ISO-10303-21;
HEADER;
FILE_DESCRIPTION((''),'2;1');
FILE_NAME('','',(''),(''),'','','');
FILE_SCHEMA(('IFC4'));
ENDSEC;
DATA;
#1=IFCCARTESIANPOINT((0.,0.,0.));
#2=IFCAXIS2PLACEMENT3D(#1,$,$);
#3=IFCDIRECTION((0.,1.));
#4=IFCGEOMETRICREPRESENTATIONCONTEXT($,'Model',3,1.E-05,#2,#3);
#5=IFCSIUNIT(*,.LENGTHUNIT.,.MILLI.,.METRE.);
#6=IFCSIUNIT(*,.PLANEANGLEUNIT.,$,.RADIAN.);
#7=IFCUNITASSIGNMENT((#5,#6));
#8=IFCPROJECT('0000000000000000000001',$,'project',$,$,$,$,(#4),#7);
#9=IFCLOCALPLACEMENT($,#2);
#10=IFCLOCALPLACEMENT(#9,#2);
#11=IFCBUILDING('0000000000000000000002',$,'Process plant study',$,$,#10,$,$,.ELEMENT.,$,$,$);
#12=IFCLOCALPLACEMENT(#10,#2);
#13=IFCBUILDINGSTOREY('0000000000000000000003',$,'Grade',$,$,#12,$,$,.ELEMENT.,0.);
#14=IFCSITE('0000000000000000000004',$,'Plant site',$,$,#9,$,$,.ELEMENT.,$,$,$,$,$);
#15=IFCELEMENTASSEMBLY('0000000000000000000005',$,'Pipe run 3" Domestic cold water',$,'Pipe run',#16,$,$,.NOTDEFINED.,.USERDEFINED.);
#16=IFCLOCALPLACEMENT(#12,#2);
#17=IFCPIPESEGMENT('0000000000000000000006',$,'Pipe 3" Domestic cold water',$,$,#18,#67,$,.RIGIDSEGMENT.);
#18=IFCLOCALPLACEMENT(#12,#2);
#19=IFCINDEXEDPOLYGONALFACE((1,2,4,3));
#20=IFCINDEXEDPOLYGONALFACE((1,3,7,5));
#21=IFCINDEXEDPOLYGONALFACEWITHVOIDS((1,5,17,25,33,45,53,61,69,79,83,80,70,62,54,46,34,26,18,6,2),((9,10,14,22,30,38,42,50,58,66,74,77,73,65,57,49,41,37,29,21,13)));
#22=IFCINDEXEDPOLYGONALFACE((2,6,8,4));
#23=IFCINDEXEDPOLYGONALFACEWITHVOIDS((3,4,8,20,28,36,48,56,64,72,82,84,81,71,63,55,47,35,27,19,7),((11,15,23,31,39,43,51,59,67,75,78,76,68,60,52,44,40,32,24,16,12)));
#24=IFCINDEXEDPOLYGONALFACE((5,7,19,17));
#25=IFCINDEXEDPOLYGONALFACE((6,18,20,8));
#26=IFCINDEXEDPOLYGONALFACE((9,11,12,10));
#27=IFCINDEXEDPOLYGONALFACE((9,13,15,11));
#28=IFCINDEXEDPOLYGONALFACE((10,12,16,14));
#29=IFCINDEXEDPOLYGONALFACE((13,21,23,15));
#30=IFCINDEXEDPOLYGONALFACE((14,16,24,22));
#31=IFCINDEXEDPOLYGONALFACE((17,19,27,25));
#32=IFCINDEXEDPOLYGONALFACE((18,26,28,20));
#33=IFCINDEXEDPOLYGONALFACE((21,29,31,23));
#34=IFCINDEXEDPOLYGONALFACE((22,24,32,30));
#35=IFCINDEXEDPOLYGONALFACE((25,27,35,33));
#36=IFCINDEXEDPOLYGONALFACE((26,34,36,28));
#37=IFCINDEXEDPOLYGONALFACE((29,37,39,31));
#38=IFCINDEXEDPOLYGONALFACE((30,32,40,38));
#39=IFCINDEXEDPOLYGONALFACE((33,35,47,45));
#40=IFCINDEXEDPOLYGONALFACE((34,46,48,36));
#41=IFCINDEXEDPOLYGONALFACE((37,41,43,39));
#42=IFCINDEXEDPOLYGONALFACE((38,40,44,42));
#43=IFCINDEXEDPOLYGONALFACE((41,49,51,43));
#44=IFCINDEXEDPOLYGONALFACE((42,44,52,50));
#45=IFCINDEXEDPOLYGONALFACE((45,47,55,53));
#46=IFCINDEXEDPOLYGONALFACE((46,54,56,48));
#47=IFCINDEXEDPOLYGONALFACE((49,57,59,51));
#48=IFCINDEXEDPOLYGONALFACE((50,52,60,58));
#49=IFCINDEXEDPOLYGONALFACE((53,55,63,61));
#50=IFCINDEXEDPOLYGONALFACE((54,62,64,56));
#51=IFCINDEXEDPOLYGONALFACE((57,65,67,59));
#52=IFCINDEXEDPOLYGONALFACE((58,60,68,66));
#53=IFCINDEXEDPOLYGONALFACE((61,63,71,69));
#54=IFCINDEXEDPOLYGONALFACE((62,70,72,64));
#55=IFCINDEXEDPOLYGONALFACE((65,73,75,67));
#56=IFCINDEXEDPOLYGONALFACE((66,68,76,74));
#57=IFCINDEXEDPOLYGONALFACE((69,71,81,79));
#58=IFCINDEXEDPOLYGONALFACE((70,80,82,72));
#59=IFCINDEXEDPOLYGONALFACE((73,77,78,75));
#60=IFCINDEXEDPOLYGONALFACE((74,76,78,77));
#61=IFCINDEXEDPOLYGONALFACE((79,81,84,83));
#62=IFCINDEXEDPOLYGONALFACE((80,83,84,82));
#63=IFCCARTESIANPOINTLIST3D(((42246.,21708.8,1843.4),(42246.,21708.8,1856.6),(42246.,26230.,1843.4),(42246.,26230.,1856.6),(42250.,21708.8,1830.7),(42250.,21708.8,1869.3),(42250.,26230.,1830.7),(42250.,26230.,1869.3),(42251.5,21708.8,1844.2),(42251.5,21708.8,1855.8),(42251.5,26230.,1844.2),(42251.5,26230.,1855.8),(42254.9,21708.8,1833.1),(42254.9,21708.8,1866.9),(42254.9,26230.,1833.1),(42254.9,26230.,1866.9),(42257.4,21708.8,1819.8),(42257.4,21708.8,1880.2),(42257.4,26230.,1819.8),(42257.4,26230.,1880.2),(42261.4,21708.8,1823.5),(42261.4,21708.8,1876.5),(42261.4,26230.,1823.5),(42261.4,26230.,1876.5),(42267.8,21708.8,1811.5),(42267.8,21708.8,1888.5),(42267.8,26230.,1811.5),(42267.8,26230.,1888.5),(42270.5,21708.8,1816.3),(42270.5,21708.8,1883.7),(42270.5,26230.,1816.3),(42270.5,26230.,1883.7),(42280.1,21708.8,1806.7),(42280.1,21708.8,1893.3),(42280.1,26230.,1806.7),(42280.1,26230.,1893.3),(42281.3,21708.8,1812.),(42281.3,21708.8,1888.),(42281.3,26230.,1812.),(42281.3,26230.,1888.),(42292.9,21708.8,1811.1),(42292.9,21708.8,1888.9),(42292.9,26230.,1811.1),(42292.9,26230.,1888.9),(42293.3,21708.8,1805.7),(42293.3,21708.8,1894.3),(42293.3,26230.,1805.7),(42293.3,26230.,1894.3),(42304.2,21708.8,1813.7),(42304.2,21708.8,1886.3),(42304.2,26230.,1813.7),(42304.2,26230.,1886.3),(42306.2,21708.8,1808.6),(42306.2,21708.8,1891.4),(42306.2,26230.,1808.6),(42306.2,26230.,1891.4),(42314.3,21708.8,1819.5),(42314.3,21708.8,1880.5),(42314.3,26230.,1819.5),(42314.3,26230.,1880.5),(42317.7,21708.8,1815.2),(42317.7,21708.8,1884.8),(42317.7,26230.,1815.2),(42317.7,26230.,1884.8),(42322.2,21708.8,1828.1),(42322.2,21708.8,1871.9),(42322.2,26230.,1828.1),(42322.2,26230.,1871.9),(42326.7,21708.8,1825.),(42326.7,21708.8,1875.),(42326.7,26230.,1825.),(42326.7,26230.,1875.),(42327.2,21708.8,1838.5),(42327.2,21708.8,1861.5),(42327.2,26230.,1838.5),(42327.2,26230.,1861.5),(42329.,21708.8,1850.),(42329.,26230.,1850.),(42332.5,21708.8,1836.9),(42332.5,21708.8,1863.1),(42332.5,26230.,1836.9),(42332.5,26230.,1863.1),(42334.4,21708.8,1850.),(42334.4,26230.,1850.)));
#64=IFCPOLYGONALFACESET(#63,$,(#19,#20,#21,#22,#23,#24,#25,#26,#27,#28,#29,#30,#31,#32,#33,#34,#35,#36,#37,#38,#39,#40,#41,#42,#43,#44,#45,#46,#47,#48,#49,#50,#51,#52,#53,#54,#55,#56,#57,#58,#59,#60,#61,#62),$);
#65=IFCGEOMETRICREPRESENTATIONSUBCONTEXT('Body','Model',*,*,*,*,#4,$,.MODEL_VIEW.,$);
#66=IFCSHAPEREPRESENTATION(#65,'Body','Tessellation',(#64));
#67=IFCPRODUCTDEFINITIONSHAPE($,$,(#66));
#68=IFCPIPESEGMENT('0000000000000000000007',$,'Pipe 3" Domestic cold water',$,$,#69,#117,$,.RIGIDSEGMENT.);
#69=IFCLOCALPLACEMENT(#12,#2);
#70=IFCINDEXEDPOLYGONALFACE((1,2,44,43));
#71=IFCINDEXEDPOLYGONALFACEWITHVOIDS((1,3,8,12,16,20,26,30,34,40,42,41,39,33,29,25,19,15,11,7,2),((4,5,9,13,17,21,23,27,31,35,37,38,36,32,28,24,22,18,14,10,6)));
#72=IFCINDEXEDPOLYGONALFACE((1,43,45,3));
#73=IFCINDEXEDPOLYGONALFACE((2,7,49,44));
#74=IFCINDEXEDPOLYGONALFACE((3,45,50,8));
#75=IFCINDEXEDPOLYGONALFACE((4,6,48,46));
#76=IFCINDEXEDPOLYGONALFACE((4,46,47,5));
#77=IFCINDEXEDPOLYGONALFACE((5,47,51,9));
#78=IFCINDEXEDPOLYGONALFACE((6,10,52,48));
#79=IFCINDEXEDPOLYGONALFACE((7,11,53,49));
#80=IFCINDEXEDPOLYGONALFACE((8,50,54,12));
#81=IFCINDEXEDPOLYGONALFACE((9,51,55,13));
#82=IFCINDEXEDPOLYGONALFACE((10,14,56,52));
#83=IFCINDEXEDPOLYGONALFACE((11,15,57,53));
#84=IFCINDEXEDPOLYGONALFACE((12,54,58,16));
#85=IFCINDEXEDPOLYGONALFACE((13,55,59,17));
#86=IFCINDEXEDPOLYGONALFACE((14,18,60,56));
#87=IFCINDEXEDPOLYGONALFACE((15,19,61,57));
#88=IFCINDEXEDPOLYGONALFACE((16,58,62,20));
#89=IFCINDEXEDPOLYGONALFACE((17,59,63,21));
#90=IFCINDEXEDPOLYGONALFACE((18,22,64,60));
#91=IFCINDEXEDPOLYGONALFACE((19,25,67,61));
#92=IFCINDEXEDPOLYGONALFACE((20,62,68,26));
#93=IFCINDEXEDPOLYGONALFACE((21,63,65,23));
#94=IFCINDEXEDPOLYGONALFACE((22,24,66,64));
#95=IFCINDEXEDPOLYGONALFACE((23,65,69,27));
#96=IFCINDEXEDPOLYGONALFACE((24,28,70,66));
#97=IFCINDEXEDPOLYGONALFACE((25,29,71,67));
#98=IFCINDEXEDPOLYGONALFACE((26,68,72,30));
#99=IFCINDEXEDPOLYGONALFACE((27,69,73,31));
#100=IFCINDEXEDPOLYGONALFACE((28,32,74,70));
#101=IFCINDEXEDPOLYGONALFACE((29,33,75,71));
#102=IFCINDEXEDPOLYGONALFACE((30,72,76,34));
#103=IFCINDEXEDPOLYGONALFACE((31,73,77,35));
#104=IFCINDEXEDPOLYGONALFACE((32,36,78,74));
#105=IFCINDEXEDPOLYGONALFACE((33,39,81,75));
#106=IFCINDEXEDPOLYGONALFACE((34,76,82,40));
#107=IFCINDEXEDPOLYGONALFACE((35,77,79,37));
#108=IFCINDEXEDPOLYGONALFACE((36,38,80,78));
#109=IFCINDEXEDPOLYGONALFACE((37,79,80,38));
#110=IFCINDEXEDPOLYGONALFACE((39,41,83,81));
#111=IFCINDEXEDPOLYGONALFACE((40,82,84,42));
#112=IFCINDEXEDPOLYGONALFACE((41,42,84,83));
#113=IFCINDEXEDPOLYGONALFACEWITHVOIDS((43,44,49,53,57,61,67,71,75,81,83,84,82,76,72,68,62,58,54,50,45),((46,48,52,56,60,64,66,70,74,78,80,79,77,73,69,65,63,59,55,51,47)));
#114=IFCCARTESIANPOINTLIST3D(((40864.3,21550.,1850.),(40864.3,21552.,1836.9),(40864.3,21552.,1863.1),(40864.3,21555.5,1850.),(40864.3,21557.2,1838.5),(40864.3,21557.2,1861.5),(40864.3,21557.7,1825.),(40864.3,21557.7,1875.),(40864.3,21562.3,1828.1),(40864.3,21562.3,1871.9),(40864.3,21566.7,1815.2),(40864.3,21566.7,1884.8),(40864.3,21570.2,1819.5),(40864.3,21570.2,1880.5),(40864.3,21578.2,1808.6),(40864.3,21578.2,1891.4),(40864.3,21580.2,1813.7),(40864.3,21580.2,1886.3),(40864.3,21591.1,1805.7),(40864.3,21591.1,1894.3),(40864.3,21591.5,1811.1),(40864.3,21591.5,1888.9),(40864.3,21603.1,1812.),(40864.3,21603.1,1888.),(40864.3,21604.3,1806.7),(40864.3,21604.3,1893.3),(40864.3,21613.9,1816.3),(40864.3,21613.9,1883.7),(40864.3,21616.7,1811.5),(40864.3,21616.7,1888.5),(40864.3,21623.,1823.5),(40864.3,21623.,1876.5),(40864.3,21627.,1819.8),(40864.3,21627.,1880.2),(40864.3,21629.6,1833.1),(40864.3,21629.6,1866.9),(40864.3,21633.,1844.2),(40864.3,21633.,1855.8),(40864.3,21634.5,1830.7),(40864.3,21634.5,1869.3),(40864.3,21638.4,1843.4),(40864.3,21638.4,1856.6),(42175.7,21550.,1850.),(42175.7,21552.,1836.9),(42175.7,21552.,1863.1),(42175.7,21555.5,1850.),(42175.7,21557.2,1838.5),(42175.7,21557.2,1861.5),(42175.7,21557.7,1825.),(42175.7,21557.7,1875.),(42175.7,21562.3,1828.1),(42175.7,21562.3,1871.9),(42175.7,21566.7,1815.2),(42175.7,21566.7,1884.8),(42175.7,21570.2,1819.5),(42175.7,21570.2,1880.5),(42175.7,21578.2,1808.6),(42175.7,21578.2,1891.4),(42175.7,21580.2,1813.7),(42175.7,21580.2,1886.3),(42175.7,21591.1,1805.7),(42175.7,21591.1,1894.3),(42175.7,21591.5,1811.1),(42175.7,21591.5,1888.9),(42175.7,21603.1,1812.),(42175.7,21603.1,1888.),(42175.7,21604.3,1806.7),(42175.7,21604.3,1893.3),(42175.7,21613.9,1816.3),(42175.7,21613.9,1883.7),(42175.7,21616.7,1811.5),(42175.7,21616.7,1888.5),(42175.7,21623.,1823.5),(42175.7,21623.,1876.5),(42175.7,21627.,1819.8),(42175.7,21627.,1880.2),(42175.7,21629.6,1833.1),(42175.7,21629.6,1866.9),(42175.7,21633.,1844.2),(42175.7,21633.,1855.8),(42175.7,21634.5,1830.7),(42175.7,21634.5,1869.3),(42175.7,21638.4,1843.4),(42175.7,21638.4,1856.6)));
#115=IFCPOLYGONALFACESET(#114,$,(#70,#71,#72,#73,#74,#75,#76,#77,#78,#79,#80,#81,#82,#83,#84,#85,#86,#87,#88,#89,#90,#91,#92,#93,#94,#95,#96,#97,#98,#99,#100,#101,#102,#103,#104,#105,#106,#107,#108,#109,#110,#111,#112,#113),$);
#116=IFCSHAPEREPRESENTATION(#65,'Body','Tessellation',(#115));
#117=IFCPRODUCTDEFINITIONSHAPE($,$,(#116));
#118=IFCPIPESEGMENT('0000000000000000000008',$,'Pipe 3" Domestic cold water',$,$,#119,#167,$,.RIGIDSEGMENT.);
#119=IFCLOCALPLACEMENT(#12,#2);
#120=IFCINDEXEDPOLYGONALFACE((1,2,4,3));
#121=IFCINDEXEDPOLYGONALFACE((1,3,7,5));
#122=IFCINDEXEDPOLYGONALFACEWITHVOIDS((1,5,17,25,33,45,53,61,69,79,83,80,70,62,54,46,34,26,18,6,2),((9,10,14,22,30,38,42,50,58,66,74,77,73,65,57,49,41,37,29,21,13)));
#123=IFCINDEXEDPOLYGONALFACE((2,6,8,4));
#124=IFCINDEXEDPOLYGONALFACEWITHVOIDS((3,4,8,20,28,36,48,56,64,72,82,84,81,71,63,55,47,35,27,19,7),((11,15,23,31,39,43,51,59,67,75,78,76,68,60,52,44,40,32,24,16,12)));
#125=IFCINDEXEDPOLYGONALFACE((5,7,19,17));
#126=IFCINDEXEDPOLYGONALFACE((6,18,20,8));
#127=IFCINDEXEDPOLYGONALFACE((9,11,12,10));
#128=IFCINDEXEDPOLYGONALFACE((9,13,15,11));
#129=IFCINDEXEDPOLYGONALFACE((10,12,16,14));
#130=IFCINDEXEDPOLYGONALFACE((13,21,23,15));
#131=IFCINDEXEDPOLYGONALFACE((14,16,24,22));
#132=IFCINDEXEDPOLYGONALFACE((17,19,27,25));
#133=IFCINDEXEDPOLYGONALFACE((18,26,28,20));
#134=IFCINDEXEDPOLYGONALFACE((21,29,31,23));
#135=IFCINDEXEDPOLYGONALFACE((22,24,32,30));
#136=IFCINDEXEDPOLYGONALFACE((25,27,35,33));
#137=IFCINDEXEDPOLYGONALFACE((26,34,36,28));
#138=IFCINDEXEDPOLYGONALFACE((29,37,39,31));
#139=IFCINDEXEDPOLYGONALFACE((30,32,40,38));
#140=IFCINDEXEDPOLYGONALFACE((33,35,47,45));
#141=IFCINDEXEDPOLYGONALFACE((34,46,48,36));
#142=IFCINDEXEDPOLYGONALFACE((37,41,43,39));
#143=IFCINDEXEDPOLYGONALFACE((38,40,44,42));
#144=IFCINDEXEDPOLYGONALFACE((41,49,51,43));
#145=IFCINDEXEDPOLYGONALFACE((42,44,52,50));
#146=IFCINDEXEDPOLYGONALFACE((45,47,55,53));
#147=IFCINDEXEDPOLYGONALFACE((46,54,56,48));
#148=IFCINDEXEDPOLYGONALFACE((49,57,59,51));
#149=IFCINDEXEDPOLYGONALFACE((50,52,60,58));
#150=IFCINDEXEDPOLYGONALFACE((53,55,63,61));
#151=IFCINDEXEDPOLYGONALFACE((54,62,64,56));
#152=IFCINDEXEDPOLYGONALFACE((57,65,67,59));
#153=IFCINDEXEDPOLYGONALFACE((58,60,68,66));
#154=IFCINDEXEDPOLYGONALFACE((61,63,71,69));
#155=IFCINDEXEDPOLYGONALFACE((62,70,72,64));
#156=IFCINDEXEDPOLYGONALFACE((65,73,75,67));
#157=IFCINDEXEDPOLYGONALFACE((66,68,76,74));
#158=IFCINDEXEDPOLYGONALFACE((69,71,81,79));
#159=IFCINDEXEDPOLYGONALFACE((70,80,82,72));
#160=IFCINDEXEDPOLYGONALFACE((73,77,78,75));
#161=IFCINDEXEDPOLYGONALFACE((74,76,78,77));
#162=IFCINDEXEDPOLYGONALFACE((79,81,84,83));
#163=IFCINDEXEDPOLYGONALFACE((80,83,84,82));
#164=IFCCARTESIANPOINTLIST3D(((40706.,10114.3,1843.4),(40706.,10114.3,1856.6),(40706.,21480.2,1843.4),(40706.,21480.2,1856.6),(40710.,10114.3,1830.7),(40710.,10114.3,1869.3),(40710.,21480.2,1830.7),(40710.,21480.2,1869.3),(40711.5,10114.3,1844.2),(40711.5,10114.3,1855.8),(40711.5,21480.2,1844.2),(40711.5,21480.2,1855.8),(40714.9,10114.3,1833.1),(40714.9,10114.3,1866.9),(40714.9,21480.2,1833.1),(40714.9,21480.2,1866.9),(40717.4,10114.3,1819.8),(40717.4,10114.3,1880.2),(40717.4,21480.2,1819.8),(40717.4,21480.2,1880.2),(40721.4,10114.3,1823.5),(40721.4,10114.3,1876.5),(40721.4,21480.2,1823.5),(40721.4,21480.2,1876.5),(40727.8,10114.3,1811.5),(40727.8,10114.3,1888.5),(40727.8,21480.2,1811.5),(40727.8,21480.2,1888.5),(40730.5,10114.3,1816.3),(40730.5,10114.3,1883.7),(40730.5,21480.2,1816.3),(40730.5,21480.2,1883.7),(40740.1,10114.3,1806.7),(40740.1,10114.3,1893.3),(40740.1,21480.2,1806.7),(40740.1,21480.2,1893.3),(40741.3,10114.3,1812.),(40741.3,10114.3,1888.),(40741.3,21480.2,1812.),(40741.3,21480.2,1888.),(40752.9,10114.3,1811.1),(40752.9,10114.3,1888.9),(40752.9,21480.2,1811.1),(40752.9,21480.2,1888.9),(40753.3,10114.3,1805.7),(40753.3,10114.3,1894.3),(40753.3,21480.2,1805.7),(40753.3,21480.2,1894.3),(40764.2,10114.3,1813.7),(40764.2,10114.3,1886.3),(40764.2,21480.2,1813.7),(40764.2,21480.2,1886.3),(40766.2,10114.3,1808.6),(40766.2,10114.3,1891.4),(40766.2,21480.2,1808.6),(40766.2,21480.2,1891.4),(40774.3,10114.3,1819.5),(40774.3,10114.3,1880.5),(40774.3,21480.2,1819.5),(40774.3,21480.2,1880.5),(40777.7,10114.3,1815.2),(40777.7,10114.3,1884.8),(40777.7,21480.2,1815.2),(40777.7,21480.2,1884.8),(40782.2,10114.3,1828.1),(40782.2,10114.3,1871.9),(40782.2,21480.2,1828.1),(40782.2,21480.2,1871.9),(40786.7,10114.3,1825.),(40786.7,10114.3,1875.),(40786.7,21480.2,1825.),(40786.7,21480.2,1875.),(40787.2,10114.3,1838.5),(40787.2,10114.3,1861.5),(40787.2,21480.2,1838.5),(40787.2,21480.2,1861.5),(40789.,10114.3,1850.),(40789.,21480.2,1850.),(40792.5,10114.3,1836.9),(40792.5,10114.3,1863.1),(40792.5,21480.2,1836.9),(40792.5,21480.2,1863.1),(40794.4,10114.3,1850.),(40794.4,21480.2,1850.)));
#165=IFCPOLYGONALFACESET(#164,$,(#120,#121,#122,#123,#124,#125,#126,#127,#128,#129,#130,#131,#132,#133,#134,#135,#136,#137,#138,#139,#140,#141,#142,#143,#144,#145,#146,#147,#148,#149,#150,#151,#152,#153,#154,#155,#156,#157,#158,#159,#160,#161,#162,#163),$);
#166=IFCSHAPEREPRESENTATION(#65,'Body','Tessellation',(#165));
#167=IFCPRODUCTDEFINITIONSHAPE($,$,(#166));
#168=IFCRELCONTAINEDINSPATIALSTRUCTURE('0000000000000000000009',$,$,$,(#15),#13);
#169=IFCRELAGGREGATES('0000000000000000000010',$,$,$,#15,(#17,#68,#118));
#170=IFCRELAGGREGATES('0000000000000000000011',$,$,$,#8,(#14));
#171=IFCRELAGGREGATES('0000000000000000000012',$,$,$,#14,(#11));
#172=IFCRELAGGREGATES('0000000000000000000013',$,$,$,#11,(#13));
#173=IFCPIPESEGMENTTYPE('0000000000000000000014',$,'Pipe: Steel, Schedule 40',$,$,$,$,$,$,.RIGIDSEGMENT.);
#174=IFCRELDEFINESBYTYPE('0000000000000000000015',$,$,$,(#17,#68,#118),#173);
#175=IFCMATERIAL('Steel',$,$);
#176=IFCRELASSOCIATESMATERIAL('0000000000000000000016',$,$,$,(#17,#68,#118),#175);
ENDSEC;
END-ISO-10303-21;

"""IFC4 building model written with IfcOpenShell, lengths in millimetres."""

from ifc_helpers import new_model, si_unit, direction, frame, origin, origin_with_axes, origin_2d, place, context, subcontext, project, spatial, hollow_circle, extrude, material, type_object, element, aggregate, save


model = new_model("IFC4")

# Units and contexts
model_context = context("Model", 3, precision=1e-05, world=origin(), true_north=direction((0.0, 1.0)))
body_context = subcontext(model_context, "Body", "Model", "MODEL_VIEW")
ifc_project = project(units=[si_unit("LENGTHUNIT", "METRE", prefix="MILLI"), si_unit("PLANEANGLEUNIT", "RADIAN")], contexts=[model_context])

# Site, building, storey
site_placement = place(None, origin())
site = spatial("IfcSite", under=ifc_project, at=site_placement, Name="Plant site", CompositionType="ELEMENT")
building_placement = place(site_placement, origin())
building = spatial("IfcBuilding", under=site, at=building_placement, Name="Process plant study", CompositionType="ELEMENT")
storey_placement = place(building_placement, origin())
storey = spatial("IfcBuildingStorey", under=building, at=storey_placement, Name="Grade", CompositionType="ELEMENT", Elevation=0.0)

# Shared definitions
ifc_material = material(Name="Steel")
pipe_segment_type = type_object("IfcPipeSegmentType", Name="Pipe: Steel, Schedule 40", PredefinedType="RIGIDSEGMENT")

# Element assembly, pipe segments
assembly_1_placement = place(storey_placement, origin_with_axes())
assembly_1 = element("IfcElementAssembly", 1, at=assembly_1_placement, inside=storey, Name="Pipe run 3\" Domestic cold water", ObjectType="Pipe run", AssemblyPlace="NOTDEFINED", PredefinedType="USERDEFINED")
pipe_segment_1_placement = place(storey_placement, origin_with_axes())
pipe_segment_1 = element("IfcPipeSegment", 2, at=pipe_segment_1_placement, type_object=pipe_segment_type, material=ifc_material, Name="Pipe 3\" Domestic cold water", PredefinedType="RIGIDSEGMENT", context=body_context, shape_type="SweptSolid", body=[
    extrude(hollow_circle(Radius=44.5, WallThickness=5.5, at=origin_2d()), frame((42290.0, 26230.0, 1850.0), z_axis=(0.0, -1.0, 0.0), x_axis=(1.0, 0.0, 0.0)), (0.0, 0.0, 1.0), 4521.2),
])
pipe_segment_2_placement = place(storey_placement, origin_with_axes())
pipe_segment_2 = element("IfcPipeSegment", 3, at=pipe_segment_2_placement, type_object=pipe_segment_type, material=ifc_material, Name="Pipe 3\" Domestic cold water", PredefinedType="RIGIDSEGMENT", context=body_context, shape_type="SweptSolid", body=[
    extrude(hollow_circle(Radius=44.5, WallThickness=5.5, at=origin_2d()), frame((42175.7, 21594.5, 1850.0), z_axis=(-1.0, 0.0, 0.0), x_axis=(0.0, -1.0, 0.0)), (0.0, 0.0, 1.0), 1311.4),
])
pipe_segment_3_placement = place(storey_placement, origin_with_axes())
pipe_segment_3 = element("IfcPipeSegment", 4, at=pipe_segment_3_placement, type_object=pipe_segment_type, material=ifc_material, Name="Pipe 3\" Domestic cold water", PredefinedType="RIGIDSEGMENT", context=body_context, shape_type="SweptSolid", body=[
    extrude(hollow_circle(Radius=44.5, WallThickness=5.5, at=origin_2d()), frame((40750.0, 21480.2, 1850.0), z_axis=(0.0, -1.0, 0.0), x_axis=(1.0, 0.0, 0.0)), (0.0, 0.0, 1.0), 11365.9),
])

aggregate(assembly_1, [pipe_segment_1, pipe_segment_2, pipe_segment_3])

save(model, "model.ifc")
